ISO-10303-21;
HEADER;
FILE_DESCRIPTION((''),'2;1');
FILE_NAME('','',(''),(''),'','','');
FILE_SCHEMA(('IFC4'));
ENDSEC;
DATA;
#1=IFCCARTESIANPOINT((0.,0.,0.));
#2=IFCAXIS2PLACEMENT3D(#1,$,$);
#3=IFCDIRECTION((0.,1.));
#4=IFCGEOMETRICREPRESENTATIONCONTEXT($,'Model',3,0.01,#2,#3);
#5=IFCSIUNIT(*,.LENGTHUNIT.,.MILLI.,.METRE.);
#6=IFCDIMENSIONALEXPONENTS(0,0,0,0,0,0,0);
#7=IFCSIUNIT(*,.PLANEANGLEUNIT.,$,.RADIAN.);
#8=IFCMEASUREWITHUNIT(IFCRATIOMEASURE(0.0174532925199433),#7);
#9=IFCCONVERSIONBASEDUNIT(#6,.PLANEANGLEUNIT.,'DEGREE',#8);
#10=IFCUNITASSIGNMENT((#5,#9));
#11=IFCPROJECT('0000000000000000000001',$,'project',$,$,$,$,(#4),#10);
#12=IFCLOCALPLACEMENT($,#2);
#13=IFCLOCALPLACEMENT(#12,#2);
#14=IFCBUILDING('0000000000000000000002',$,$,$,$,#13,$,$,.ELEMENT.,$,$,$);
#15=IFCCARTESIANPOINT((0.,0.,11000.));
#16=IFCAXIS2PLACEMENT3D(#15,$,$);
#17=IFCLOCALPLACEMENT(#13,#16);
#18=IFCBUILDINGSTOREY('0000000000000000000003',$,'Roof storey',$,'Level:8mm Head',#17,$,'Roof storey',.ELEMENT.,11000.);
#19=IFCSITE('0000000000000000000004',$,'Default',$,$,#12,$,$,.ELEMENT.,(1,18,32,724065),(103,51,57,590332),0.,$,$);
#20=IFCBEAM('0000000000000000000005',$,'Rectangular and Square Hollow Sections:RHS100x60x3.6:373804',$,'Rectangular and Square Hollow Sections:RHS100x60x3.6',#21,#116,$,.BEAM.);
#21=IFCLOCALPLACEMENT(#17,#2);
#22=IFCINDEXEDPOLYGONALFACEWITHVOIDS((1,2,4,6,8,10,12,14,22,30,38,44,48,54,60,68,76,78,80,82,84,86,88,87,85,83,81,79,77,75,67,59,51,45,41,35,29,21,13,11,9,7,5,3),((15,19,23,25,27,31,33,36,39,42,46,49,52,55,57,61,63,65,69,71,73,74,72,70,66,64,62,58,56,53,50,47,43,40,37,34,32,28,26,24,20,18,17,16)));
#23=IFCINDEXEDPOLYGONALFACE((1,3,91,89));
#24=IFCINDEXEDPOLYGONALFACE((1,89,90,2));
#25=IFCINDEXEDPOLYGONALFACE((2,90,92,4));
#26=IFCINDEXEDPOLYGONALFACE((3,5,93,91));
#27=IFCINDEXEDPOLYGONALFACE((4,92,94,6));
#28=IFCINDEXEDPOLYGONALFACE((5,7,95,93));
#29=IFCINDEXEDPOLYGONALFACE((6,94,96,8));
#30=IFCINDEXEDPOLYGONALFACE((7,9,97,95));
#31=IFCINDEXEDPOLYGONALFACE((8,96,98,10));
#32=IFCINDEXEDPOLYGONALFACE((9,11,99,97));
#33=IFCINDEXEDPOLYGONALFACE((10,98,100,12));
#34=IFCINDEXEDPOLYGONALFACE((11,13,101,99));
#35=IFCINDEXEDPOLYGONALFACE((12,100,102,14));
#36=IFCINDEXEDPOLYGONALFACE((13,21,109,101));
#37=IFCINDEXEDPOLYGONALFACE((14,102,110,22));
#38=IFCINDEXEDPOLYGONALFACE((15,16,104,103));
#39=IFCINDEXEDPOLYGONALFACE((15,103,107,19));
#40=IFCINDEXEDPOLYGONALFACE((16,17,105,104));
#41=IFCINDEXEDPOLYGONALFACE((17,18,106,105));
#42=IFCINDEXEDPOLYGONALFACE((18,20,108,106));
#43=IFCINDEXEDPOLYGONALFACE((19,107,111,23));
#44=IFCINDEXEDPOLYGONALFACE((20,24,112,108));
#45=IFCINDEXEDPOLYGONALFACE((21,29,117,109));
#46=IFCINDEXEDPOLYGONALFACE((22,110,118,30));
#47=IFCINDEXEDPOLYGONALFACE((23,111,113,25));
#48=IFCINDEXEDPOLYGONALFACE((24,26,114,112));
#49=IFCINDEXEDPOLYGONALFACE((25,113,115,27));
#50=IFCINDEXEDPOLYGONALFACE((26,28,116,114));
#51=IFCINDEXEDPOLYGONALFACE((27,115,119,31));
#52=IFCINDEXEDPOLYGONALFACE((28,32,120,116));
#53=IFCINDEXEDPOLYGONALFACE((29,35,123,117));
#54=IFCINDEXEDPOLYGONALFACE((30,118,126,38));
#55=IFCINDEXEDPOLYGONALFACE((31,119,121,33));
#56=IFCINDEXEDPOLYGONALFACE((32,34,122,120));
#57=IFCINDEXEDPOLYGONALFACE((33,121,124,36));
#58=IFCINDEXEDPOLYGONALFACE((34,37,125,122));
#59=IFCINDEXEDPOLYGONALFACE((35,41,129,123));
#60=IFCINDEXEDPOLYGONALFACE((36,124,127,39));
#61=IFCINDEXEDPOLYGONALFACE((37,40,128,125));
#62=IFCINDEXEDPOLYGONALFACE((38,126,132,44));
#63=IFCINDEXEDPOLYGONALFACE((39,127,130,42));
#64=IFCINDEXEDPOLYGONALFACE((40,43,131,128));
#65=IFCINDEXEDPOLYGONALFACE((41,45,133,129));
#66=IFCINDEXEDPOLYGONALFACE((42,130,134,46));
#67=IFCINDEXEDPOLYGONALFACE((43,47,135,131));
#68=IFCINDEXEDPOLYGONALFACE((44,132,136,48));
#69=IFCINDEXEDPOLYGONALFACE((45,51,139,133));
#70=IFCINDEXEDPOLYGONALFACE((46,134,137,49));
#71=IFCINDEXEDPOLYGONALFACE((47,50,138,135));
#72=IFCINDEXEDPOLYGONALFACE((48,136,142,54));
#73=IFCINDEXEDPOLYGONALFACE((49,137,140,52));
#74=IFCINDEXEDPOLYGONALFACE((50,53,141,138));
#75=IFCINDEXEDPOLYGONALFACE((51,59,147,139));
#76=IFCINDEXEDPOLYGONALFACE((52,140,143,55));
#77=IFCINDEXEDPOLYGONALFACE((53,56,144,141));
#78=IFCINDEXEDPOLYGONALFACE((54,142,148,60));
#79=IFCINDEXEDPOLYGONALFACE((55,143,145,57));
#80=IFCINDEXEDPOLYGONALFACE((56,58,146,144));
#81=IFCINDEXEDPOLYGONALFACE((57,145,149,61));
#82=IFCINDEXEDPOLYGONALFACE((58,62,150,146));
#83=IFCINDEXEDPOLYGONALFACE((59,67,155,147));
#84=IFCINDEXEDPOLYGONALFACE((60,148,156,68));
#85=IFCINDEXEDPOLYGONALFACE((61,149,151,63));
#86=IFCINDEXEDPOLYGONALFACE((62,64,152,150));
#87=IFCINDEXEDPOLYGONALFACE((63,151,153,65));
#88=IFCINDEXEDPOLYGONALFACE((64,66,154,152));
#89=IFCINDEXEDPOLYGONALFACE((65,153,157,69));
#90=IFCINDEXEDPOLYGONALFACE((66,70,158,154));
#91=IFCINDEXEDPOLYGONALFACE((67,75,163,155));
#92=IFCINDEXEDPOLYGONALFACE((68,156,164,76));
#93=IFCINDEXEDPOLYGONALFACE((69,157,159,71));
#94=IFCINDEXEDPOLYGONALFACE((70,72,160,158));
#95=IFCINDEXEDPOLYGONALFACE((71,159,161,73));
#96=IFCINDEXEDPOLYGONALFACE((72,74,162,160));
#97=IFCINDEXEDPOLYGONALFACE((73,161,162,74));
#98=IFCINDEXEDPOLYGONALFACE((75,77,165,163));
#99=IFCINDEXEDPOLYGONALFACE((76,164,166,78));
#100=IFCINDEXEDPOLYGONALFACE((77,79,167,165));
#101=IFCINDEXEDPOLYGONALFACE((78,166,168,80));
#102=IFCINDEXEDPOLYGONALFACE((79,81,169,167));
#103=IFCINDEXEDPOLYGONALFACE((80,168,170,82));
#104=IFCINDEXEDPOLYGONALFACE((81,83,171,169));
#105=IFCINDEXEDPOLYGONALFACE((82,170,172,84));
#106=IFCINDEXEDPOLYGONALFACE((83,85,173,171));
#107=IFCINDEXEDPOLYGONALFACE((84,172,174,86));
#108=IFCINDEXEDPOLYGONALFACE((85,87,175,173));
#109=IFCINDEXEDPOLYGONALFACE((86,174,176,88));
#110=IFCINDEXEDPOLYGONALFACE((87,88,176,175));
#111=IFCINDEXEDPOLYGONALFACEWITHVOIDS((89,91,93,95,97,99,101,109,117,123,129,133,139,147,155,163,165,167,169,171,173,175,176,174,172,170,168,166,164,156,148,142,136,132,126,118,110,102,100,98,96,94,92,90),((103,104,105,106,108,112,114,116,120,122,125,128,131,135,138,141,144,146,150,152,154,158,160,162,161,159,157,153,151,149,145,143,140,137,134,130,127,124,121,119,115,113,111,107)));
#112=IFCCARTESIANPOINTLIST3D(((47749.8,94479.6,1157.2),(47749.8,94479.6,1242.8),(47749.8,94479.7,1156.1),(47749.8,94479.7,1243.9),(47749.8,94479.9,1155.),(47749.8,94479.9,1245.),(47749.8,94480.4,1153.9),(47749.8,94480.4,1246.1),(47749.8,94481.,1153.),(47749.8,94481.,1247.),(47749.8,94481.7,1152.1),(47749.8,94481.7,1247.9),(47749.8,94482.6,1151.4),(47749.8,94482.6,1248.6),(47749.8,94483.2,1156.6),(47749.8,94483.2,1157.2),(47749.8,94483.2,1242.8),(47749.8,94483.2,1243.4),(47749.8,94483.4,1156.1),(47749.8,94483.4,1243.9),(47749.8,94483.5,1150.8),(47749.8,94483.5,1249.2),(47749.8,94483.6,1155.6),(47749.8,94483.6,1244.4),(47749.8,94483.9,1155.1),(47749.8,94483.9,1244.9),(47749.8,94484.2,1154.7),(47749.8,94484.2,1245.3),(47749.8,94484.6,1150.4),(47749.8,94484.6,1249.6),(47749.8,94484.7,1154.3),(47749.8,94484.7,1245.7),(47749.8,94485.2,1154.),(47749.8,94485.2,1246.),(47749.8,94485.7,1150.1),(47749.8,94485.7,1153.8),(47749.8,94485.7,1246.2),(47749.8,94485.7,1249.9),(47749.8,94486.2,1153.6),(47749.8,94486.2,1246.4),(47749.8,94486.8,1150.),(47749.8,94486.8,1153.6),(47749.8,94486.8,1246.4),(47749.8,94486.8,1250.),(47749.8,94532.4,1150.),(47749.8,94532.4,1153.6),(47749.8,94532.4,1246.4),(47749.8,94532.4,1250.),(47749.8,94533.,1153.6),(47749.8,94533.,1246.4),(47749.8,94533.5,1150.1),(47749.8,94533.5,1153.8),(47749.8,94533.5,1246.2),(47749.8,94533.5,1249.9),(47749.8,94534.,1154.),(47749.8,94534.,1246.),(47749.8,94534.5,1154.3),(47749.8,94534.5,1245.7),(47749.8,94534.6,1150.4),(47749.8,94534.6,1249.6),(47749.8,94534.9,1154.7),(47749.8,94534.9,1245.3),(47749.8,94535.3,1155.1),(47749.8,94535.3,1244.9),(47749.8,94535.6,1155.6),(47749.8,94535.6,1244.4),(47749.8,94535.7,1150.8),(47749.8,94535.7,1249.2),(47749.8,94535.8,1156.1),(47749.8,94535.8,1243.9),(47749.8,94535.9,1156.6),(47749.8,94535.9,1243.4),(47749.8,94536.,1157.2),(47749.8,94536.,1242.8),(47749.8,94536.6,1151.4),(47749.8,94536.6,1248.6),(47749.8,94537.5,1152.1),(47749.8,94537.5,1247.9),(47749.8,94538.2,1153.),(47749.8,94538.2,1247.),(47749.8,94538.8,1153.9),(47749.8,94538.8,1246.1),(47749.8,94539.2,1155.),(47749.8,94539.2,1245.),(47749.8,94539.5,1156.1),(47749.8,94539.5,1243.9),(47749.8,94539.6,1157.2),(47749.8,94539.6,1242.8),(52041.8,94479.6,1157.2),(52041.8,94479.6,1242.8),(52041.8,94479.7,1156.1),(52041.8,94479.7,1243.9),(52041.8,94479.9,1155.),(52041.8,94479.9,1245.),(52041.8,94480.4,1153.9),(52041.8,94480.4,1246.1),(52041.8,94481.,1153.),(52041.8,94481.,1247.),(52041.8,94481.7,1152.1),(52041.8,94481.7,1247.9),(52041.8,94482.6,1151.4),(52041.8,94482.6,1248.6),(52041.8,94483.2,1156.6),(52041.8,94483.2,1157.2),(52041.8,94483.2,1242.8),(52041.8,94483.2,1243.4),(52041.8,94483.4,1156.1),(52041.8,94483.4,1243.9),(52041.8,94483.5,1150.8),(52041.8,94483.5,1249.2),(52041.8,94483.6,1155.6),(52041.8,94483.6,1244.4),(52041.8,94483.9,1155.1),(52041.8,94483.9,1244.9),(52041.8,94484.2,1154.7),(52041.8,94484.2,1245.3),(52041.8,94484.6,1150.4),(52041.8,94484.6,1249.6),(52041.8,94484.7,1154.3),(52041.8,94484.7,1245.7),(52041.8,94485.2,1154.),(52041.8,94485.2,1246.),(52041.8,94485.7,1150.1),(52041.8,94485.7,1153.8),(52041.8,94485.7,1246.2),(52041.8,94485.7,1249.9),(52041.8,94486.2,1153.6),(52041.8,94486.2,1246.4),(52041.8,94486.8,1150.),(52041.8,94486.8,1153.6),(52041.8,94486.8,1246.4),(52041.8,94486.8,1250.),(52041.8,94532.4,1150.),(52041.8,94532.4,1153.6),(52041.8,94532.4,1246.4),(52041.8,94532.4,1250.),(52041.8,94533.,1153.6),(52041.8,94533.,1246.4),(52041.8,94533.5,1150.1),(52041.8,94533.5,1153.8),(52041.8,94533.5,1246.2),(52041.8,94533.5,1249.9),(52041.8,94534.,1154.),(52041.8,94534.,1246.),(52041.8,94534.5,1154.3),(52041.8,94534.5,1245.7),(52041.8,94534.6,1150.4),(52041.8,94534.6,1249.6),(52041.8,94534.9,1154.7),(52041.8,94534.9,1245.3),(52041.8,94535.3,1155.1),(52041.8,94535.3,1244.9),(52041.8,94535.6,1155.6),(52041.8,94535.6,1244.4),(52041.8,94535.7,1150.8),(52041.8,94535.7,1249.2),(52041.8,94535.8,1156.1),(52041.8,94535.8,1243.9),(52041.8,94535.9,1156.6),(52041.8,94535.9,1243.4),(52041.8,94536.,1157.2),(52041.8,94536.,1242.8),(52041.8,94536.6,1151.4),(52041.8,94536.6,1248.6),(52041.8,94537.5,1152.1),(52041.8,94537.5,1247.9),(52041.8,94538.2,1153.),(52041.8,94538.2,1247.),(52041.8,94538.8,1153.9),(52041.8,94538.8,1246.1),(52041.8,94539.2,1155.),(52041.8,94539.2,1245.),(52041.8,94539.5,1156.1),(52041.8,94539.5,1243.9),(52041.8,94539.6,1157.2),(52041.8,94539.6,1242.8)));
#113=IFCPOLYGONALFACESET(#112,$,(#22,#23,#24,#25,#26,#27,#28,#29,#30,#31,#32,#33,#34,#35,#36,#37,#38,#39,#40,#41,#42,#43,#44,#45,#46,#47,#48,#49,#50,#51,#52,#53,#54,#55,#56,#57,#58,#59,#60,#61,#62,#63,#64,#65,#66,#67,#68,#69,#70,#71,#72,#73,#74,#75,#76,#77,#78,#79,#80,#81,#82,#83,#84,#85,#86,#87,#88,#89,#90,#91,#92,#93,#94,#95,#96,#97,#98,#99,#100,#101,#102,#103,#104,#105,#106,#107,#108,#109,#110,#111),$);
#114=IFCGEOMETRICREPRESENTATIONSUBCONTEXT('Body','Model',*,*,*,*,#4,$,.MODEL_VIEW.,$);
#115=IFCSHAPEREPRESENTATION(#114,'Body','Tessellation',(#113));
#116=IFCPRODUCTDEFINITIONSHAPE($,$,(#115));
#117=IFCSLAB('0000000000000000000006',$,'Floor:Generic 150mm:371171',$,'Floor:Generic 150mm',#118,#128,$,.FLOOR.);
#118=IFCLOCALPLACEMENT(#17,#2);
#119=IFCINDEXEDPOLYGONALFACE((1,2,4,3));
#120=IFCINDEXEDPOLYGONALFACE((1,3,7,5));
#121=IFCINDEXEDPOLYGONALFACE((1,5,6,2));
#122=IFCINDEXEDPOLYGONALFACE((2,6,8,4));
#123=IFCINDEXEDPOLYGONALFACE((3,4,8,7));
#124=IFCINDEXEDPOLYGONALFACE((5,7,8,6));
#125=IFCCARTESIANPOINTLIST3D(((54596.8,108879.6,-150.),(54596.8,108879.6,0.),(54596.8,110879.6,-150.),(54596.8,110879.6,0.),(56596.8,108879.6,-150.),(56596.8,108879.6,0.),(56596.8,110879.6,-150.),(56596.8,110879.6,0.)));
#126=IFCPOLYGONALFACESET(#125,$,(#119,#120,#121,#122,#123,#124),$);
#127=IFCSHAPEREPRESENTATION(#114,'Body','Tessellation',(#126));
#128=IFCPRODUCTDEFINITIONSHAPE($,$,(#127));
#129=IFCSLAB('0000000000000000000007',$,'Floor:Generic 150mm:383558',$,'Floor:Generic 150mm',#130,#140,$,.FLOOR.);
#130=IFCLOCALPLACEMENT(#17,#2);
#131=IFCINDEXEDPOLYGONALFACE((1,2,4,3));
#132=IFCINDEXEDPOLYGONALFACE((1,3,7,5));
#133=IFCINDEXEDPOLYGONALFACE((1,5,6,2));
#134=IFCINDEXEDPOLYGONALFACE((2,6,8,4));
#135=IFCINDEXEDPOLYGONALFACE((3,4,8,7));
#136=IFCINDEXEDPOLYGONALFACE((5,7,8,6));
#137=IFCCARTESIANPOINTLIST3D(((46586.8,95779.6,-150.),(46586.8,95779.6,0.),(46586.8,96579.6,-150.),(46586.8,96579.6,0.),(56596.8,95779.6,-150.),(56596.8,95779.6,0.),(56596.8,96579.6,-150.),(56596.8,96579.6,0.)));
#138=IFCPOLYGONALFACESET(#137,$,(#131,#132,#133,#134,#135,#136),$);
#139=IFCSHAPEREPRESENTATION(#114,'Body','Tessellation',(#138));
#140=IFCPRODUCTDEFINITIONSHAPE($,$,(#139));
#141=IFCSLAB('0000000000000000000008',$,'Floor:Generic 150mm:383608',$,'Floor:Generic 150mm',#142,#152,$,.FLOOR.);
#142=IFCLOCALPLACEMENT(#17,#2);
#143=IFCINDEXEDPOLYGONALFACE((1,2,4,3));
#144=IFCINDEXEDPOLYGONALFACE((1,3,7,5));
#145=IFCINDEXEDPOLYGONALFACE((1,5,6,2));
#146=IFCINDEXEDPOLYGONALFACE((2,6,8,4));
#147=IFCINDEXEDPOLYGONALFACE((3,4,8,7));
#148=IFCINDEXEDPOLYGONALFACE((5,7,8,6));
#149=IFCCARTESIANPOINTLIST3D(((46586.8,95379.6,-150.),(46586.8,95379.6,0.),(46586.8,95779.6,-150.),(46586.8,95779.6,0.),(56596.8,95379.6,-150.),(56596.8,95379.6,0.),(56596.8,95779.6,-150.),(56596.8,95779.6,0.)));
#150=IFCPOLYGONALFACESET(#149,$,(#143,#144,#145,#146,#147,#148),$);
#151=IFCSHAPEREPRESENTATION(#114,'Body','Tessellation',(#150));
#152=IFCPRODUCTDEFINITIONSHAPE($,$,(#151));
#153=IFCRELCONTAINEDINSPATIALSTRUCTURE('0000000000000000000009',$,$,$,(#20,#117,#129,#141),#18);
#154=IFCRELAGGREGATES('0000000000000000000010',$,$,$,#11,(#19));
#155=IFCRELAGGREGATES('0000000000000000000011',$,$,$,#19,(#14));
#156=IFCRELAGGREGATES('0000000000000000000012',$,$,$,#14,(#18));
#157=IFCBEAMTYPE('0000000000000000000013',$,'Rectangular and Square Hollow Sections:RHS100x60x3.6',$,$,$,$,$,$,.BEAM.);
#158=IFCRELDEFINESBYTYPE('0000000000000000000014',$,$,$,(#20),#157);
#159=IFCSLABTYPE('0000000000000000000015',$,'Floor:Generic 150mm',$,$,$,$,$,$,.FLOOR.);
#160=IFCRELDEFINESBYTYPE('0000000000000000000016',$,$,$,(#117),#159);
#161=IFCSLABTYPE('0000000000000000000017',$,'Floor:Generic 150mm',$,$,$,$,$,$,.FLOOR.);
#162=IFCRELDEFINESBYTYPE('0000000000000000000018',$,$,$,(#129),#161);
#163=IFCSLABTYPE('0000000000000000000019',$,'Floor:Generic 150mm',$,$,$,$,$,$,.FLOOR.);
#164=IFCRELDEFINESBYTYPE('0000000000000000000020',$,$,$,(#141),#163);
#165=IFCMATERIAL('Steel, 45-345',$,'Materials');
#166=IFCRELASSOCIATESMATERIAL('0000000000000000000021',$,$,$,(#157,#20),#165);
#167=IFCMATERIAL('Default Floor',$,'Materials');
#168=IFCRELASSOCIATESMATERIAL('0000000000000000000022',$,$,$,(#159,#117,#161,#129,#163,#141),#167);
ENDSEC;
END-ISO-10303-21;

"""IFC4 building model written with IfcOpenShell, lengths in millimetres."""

from ifc_helpers import new_model, entity, si_unit, converted_unit, direction, frame, origin, place, context, subcontext, project, spatial, indexed_curve, outline, extrude, source, transform, mapped, material, type_object, type_shapes, element, save


model = new_model("IFC4")

# Units and contexts
model_context = context("Model", 3, precision=0.01, world=origin(), true_north=direction((0.0, 1.0)))
body_context = subcontext(model_context, "Body", "Model", "MODEL_VIEW")
ifc_project = project(units=[si_unit("LENGTHUNIT", "METRE", prefix="MILLI"), converted_unit("PLANEANGLEUNIT", "DEGREE", entity("IfcRatioMeasure", 0.0174532925199433), si_unit("PLANEANGLEUNIT", "RADIAN"), dimensions=[0, 0, 0, 0, 0, 0, 0])], contexts=[model_context])

# Site, building, storey
site_placement = place(None, origin())
site = spatial("IfcSite", under=ifc_project, at=site_placement, Name="Default", CompositionType="ELEMENT", RefLatitude=(1, 18, 32, 724065), RefLongitude=(103, 51, 57, 590332), RefElevation=0.0)
building_placement = place(site_placement, origin())
building = spatial("IfcBuilding", under=site, at=building_placement, CompositionType="ELEMENT")
storey_placement = place(building_placement, frame((0.0, 0.0, 11000.0)))
storey = spatial("IfcBuildingStorey", under=building, at=storey_placement, Name="Roof storey", ObjectType="Level:8mm Head", LongName="Roof storey", CompositionType="ELEMENT", Elevation=11000.0)

# Beam
ifc_material_1 = material(Name="Steel, 45-345", Category="Materials")
beam_type_1 = type_object("IfcBeamType", Name="Rectangular and Square Hollow Sections:RHS100x60x3.6", PredefinedType="BEAM", material=ifc_material_1)
shared_shape_1 = source(origin(), body_context, "Body", "SweptSolid", [
    extrude(outline(indexed_curve([(-30.0, -42.8), (-29.9, -43.9), (-29.6, -45.0), (-29.2, -46.1), (-28.6, -47.0), (-27.9, -47.9), (-27.0, -48.6), (-26.1, -49.2), (-25.0, -49.6), (-23.9, -49.9), (-22.8, -50.0), (22.8, -50.0), (23.9, -49.9), (25.0, -49.6), (26.1, -49.2), (27.0, -48.6), (27.9, -47.9), (28.6, -47.0), (29.2, -46.1), (29.6, -45.0), (29.9, -43.9), (30.0, -42.8), (30.0, 42.8), (29.9, 43.9), (29.6, 45.0), (29.2, 46.1), (28.6, 47.0), (27.9, 47.9), (27.0, 48.6), (26.1, 49.2), (25.0, 49.6), (23.9, 49.9), (22.8, 50.0), (-22.8, 50.0), (-23.9, 49.9), (-25.0, 49.6), (-26.1, 49.2), (-27.0, 48.6), (-27.9, 47.9), (-28.6, 47.0), (-29.2, 46.1), (-29.6, 45.0), (-29.9, 43.9), (-30.0, 42.8), (-30.0, -42.8)], self_intersect=False), holes=[indexed_curve([(22.8, -46.4), (-22.8, -46.4), (-23.4, -46.4), (-23.9, -46.2), (-24.4, -46.0), (-24.9, -45.7), (-25.3, -45.3), (-25.7, -44.9), (-26.0, -44.4), (-26.2, -43.9), (-26.4, -43.4), (-26.4, -42.8), (-26.4, 42.8), (-26.4, 43.4), (-26.2, 43.9), (-26.0, 44.4), (-25.7, 44.9), (-25.3, 45.3), (-24.9, 45.7), (-24.4, 46.0), (-23.9, 46.2), (-23.4, 46.4), (-22.8, 46.4), (22.8, 46.4), (23.4, 46.4), (23.9, 46.2), (24.4, 46.0), (24.9, 45.7), (25.3, 45.3), (25.7, 44.9), (26.0, 44.4), (26.2, 43.9), (26.4, 43.4), (26.4, 42.8), (26.4, -42.8), (26.4, -43.4), (26.2, -43.9), (26.0, -44.4), (25.7, -44.9), (25.3, -45.3), (24.9, -45.7), (24.4, -46.0), (23.9, -46.2), (23.4, -46.4), (22.8, -46.4)], self_intersect=False)]), frame((-2139.5, 0.0, 0.0), z_axis=(1.0, 0.0, 0.0), x_axis=(0.0, -1.0, 0.0)), (0.0, 0.0, 1.0), 4292.0),
])
type_shapes(beam_type_1, [shared_shape_1])
beam_1_placement = place(storey_placement, frame((49889.3, 94509.6, 1200.0)))
element("IfcBeam", 1, at=beam_1_placement, inside=storey, type_object=beam_type_1, material=ifc_material_1, Name="Rectangular and Square Hollow Sections:RHS100x60x3.6:373804", ObjectType="Rectangular and Square Hollow Sections:RHS100x60x3.6", PredefinedType="BEAM", context=body_context, shape_type="MappedRepresentation", body=[
    mapped(shared_shape_1, transform((0.0, 0.0, 0.0), scale=1.0)),
])

# Slabs
ifc_material_2 = material(Name="Default Floor", Category="Materials")
slab_type_1 = type_object("IfcSlabType", Name="Floor:Generic 150mm", PredefinedType="FLOOR", material=ifc_material_2)
slab_1_placement = place(storey_placement, origin())
element("IfcSlab", 2, at=slab_1_placement, inside=storey, type_object=slab_type_1, material=ifc_material_2, Name="Floor:Generic 150mm:371171", ObjectType="Floor:Generic 150mm", PredefinedType="FLOOR", context=body_context, shape_type="SweptSolid", body=[
    extrude(outline(indexed_curve([(-1000.0, -1000.0), (1000.0, -1000.0), (1000.0, 1000.0), (-1000.0, 1000.0), (-1000.0, -1000.0)], self_intersect=False)), frame((55596.8, 109879.6, 0.0), z_axis=(0.0, 0.0, -1.0), x_axis=(0.0, 1.0, 0.0)), (0.0, 0.0, 1.0), 150.0),
])
slab_type_2 = type_object("IfcSlabType", Name="Floor:Generic 150mm", PredefinedType="FLOOR", material=ifc_material_2)
slab_2_placement = place(storey_placement, origin())
element("IfcSlab", 3, at=slab_2_placement, inside=storey, type_object=slab_type_2, material=ifc_material_2, Name="Floor:Generic 150mm:383558", ObjectType="Floor:Generic 150mm", PredefinedType="FLOOR", context=body_context, shape_type="SweptSolid", body=[
    extrude(outline(indexed_curve([(-400.0, -5005.0), (400.0, -5005.0), (400.0, 5005.0), (-400.0, 5005.0), (-400.0, -5005.0)], self_intersect=False)), frame((51591.8, 96179.6, 0.0), z_axis=(0.0, 0.0, -1.0), x_axis=(0.0, 1.0, 0.0)), (0.0, 0.0, 1.0), 150.0),
])
slab_type_3 = type_object("IfcSlabType", Name="Floor:Generic 150mm", PredefinedType="FLOOR", material=ifc_material_2)
slab_3_placement = place(storey_placement, origin())
element("IfcSlab", 4, at=slab_3_placement, inside=storey, type_object=slab_type_3, material=ifc_material_2, Name="Floor:Generic 150mm:383608", ObjectType="Floor:Generic 150mm", PredefinedType="FLOOR", context=body_context, shape_type="SweptSolid", body=[
    extrude(outline(indexed_curve([(-200.0, -5005.0), (200.0, -5005.0), (200.0, 5005.0), (-200.0, 5005.0), (-200.0, -5005.0)], self_intersect=False)), frame((51591.8, 95579.6, 0.0), z_axis=(0.0, 0.0, -1.0), x_axis=(0.0, 1.0, 0.0)), (0.0, 0.0, 1.0), 150.0),
])

save(model, "model.ifc")
